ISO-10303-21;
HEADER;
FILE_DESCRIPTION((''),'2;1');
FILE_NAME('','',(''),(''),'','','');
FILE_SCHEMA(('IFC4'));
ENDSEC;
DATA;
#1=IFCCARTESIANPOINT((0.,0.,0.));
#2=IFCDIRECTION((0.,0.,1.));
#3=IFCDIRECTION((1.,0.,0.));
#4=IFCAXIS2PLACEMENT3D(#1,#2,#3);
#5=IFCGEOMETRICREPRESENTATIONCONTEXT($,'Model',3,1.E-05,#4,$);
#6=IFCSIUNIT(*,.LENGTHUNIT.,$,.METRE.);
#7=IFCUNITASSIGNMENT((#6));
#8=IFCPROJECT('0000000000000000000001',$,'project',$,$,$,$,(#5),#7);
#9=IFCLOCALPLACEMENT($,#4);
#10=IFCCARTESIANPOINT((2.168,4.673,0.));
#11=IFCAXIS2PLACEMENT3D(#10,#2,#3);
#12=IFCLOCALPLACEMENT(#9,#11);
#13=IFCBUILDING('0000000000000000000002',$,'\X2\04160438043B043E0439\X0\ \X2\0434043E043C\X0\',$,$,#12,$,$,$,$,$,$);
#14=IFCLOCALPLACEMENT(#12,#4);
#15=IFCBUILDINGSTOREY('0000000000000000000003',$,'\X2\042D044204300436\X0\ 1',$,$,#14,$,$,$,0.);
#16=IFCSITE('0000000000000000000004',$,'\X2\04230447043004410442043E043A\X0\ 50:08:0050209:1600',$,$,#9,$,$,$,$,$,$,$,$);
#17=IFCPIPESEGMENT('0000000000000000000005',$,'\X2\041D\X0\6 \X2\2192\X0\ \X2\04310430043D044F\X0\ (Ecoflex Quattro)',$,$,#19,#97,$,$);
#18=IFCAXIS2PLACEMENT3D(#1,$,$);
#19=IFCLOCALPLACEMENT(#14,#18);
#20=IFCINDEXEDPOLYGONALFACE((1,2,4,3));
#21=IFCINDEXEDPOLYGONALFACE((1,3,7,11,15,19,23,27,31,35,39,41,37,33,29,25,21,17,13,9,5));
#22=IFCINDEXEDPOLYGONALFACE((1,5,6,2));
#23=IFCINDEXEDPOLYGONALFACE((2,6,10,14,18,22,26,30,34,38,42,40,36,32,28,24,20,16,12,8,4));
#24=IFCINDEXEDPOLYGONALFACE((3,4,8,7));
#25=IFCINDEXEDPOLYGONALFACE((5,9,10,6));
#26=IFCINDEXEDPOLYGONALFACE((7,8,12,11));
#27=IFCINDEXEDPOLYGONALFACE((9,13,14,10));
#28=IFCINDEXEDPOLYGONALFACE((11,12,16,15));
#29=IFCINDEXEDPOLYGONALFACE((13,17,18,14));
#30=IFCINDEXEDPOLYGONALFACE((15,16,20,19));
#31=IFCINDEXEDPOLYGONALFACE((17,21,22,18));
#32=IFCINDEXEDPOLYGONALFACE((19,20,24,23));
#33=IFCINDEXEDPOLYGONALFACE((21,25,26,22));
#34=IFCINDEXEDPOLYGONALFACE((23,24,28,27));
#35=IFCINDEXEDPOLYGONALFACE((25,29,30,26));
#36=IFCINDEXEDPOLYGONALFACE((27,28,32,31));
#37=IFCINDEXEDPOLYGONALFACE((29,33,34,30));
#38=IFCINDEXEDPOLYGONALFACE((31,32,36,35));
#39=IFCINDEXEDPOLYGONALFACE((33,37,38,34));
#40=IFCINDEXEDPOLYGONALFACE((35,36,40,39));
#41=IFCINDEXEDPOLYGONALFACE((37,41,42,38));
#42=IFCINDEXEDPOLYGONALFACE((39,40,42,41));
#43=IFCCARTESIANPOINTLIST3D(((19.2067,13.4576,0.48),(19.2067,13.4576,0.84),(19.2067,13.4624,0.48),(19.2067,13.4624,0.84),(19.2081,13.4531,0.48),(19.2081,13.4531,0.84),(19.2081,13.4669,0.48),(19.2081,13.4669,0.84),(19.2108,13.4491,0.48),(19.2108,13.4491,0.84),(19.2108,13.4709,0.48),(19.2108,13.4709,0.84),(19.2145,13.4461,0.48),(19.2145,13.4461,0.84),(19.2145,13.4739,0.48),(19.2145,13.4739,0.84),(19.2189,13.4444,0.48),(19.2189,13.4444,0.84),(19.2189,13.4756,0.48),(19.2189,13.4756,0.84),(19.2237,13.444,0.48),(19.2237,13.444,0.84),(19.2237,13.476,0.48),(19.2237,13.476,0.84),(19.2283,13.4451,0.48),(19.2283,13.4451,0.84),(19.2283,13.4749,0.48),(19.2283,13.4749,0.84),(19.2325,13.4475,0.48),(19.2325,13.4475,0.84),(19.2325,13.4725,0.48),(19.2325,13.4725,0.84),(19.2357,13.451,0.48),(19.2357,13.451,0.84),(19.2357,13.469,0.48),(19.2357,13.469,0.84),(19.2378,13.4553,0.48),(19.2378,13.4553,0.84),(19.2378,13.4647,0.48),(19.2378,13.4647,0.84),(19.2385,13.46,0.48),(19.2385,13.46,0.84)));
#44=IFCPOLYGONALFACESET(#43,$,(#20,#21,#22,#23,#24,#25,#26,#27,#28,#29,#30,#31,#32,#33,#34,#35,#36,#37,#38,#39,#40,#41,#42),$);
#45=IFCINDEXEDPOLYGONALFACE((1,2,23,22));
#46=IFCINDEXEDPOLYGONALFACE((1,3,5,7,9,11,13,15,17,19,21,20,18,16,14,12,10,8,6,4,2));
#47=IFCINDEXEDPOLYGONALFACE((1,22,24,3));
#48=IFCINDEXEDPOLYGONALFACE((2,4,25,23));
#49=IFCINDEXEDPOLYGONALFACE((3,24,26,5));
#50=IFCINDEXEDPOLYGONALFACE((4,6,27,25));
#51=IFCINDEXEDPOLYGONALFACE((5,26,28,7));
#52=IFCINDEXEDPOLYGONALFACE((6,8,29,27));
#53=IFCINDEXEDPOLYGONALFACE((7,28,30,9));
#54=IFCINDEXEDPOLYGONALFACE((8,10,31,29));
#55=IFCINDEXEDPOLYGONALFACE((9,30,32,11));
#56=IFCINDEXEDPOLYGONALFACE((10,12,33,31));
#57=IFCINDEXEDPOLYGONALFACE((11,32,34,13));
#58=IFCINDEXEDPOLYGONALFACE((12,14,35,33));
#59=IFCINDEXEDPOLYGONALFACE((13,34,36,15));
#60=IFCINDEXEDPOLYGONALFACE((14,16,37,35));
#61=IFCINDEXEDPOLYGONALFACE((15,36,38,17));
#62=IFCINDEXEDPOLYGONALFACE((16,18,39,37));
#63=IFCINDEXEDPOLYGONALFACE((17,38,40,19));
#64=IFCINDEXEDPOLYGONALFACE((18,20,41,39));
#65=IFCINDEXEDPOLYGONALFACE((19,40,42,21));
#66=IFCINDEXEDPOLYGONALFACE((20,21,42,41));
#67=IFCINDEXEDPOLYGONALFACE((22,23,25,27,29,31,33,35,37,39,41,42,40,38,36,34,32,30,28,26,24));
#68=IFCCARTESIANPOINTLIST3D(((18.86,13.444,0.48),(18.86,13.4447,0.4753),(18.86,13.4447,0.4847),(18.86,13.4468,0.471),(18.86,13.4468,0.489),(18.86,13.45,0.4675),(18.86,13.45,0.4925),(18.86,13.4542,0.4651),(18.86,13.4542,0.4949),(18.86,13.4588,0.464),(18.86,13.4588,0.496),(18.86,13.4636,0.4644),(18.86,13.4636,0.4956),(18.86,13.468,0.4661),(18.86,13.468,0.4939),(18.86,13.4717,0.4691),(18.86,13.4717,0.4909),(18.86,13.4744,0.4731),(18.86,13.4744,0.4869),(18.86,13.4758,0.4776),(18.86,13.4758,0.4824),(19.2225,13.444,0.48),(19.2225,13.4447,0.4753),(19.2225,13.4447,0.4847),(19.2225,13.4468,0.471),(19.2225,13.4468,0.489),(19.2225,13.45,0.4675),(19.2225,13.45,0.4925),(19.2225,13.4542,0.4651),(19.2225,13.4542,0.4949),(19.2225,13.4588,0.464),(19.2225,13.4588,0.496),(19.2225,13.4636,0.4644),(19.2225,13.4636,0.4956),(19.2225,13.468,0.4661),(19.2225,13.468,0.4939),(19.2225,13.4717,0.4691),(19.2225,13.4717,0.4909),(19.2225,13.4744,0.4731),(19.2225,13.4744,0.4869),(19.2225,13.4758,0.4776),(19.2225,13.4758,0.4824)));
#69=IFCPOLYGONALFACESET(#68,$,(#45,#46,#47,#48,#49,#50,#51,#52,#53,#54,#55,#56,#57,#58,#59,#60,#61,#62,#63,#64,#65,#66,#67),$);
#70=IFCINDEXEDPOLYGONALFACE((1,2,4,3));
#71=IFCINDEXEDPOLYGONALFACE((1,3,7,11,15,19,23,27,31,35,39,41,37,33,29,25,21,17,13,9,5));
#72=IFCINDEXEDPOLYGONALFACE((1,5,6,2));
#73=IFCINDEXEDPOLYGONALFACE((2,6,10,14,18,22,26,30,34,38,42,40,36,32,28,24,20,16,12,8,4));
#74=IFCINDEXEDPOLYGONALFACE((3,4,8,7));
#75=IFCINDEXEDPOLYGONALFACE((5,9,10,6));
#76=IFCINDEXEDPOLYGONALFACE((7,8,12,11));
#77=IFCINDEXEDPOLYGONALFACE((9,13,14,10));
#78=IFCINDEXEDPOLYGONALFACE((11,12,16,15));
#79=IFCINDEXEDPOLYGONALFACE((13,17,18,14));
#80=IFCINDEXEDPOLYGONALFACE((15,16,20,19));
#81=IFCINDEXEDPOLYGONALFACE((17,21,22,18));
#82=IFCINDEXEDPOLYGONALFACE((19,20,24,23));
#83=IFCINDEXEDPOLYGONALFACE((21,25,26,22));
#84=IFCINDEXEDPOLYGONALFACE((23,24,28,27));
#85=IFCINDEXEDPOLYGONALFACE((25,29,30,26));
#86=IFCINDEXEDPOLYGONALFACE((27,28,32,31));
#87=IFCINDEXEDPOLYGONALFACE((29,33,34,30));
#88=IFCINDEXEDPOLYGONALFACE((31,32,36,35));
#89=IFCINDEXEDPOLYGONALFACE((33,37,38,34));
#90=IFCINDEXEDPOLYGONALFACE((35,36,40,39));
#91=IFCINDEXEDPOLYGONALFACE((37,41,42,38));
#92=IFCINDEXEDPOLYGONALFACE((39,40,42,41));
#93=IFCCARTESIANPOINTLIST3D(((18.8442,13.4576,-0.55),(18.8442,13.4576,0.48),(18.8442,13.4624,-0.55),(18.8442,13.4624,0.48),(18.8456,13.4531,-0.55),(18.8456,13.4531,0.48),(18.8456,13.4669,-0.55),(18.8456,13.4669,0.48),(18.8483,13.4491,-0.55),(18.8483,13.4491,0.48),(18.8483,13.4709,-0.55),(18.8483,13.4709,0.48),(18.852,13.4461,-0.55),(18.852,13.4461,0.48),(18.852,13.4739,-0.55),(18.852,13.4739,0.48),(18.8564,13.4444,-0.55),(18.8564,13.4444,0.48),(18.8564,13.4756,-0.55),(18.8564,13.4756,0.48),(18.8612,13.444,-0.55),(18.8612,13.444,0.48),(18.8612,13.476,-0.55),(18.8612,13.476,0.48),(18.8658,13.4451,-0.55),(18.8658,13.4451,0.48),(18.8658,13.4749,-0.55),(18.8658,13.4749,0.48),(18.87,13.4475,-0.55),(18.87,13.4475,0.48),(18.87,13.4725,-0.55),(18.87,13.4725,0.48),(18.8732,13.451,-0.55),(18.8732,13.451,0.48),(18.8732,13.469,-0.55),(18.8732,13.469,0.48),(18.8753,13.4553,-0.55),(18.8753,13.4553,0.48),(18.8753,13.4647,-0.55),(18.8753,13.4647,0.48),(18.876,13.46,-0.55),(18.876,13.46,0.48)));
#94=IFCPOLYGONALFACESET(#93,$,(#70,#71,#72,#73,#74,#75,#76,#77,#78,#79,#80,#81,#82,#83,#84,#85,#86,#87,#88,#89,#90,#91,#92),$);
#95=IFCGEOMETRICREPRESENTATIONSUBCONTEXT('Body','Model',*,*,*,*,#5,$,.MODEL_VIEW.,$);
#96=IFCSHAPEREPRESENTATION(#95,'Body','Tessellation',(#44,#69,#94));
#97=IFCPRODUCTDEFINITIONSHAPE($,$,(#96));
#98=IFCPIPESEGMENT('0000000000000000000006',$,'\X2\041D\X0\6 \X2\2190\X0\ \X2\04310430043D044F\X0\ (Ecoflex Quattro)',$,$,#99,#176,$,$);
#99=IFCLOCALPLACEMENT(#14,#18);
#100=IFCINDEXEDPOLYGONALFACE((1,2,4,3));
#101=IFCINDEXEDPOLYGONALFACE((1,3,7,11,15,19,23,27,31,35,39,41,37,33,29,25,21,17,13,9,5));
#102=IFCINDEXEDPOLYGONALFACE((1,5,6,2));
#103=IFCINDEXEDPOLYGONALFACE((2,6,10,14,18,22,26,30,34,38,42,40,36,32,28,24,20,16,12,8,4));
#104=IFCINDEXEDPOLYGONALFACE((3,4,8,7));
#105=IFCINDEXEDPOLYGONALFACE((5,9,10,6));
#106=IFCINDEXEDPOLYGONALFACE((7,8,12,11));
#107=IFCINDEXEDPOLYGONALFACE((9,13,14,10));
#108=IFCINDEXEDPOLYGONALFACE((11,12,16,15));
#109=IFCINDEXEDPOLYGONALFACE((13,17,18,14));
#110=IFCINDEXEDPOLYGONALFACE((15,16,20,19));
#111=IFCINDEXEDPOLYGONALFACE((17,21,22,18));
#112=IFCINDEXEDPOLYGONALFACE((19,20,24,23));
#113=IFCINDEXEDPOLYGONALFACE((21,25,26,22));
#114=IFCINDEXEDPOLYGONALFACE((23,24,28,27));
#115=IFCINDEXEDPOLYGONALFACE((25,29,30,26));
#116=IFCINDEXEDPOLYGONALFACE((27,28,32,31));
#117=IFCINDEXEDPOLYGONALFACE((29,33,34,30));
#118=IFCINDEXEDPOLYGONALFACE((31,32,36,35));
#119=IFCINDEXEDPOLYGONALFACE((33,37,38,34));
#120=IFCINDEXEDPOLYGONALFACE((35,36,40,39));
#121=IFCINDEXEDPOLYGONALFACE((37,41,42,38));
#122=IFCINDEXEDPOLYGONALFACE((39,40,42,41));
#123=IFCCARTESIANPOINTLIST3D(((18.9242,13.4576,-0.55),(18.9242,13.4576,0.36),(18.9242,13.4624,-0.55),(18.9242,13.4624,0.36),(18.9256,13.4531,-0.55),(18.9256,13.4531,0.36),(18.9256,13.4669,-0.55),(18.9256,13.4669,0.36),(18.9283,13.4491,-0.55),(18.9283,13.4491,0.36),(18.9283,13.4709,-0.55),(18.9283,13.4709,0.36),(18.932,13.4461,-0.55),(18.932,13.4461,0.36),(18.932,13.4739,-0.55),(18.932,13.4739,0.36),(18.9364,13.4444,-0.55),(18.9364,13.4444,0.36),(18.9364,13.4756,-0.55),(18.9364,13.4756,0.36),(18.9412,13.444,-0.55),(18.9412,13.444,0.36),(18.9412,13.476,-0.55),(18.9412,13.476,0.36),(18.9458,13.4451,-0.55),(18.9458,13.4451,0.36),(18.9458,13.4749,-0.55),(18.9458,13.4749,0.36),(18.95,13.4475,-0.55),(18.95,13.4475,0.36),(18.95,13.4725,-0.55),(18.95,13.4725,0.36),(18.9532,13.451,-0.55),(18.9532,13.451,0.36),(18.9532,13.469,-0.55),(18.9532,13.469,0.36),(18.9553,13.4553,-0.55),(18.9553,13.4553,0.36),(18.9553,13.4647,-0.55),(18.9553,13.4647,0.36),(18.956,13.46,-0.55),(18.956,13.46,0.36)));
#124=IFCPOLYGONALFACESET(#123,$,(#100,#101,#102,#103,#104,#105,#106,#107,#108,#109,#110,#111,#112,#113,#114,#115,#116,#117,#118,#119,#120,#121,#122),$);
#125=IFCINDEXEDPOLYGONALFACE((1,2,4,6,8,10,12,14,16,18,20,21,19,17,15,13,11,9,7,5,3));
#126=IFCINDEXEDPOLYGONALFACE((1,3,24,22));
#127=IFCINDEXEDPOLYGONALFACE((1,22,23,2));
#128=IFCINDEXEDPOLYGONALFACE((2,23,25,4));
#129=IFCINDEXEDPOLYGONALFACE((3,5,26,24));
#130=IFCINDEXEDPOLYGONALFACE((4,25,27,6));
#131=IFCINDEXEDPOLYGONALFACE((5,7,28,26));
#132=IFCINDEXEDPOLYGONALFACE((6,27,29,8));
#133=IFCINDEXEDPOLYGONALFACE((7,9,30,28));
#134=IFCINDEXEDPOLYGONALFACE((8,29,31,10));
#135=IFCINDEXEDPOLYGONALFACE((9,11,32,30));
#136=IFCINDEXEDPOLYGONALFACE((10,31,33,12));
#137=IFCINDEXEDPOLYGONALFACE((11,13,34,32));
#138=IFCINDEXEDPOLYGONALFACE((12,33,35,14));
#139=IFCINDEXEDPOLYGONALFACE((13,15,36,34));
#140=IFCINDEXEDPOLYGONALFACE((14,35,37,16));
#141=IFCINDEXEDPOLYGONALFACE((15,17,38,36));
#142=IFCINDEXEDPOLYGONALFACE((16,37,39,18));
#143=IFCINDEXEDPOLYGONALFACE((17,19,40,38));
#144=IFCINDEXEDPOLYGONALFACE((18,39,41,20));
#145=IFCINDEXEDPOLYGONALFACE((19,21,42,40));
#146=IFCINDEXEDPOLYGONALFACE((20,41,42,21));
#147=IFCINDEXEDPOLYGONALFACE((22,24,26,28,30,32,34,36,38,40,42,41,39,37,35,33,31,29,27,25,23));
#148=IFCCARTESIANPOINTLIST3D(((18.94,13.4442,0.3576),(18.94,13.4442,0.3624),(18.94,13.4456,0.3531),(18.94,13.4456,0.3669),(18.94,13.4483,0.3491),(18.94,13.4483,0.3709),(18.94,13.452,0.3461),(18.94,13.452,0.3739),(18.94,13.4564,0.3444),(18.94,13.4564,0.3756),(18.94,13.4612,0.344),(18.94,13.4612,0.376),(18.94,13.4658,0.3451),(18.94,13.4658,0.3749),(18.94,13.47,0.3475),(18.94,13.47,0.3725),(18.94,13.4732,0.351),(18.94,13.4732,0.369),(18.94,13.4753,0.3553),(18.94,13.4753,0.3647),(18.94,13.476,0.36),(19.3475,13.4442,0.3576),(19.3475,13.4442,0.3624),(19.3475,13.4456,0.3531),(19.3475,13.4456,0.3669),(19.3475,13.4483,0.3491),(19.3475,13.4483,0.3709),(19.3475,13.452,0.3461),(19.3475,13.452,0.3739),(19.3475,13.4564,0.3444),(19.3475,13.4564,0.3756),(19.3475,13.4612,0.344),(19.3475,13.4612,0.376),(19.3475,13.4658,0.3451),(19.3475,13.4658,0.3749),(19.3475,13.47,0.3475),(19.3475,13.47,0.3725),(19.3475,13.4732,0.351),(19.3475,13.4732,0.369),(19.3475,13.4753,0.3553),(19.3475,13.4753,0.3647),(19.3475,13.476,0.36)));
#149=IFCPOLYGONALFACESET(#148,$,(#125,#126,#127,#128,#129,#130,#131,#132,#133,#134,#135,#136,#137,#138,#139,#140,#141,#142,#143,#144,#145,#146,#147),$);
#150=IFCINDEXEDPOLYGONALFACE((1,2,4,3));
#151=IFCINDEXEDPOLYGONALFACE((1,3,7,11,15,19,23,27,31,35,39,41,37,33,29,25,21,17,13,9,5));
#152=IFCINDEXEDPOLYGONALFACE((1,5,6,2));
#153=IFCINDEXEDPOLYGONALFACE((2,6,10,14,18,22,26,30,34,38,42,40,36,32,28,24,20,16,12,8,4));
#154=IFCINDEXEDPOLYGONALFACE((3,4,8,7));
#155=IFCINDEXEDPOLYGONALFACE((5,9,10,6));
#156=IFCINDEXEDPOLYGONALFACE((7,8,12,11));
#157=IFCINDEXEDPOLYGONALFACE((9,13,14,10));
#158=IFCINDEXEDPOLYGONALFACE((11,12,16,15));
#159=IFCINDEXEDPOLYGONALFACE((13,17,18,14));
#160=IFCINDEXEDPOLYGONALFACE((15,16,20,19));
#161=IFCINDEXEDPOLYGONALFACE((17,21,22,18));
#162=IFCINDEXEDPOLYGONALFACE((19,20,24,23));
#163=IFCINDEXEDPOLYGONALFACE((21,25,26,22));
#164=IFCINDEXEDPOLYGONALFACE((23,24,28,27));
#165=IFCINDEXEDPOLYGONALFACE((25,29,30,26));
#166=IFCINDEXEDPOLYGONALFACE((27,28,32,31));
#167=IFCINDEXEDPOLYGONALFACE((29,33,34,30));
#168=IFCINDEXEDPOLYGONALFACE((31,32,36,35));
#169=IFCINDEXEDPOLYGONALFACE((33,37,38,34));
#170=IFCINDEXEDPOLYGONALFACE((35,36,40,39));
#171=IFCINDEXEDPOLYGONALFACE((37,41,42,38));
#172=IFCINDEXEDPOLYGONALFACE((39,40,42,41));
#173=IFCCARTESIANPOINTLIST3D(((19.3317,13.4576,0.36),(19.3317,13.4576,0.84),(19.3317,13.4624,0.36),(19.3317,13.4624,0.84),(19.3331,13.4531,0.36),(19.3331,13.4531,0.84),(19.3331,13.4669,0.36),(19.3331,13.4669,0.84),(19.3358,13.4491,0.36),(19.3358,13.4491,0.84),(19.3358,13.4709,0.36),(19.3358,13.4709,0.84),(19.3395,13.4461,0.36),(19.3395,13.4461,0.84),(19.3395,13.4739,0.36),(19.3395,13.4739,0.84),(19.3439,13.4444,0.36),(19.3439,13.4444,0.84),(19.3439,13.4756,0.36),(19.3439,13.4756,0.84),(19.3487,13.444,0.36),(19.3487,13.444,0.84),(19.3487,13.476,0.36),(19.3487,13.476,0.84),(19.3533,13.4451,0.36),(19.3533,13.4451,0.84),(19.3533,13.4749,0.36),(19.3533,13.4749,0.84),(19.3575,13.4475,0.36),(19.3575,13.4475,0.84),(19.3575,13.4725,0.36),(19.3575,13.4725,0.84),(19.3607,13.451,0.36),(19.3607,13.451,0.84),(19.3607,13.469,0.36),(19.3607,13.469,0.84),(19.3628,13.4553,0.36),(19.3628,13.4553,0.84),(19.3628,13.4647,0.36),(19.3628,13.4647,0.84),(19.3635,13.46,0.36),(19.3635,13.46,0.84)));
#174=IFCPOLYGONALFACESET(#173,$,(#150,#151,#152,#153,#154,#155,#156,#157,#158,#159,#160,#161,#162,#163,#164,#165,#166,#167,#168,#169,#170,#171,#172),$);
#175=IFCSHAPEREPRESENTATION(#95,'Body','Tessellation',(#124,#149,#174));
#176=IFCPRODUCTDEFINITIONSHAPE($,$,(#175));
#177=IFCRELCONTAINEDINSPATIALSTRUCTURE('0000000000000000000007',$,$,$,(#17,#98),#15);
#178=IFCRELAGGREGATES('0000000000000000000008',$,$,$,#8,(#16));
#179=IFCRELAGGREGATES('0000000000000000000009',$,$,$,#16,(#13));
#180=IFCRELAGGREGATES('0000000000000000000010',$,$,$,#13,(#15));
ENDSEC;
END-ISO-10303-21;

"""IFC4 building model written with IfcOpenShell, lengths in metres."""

from ifc_helpers import new_model, si_unit, frame, origin_with_axes, origin_2d, place, context, subcontext, project, spatial, circle, extrude, element, save


model = new_model("IFC4")

# Units and contexts
model_context = context("Model", 3, precision=1e-05, world=origin_with_axes())
body_context = subcontext(model_context, "Body", "Model", "MODEL_VIEW")
ifc_project = project(units=[si_unit("LENGTHUNIT", "METRE")], contexts=[model_context])

# Site, building, storey
site_placement = place(None, origin_with_axes())
site = spatial("IfcSite", under=ifc_project, at=site_placement, Name="Участок 50:08:0050209:1600")
building_placement = place(site_placement, frame((2.168, 4.673, 0.0), z_axis=(0.0, 0.0, 1.0), x_axis=(1.0, 0.0, 0.0)))
building = spatial("IfcBuilding", under=site, at=building_placement, Name="Жилой дом")
storey_placement = place(building_placement, origin_with_axes())
storey = spatial("IfcBuildingStorey", under=building, at=storey_placement, Name="Этаж 1", Elevation=0.0)

# Pipe segments
pipe_segment_1_placement = place(storey_placement, origin_with_axes())
element("IfcPipeSegment", 1, at=pipe_segment_1_placement, inside=storey, Name="Н6 → баня (Ecoflex Quattro)", context=body_context, shape_type="SweptSolid", body=[
    extrude(circle(Radius=0.016, at=origin_2d()), frame((19.2225, 13.46, 0.84), z_axis=(0.0, 0.0, -1.0), x_axis=(1.0, 0.0, 0.0)), (0.0, 0.0, 1.0), 0.36),
    extrude(circle(Radius=0.016, at=origin_2d()), frame((19.2225, 13.46, 0.48), z_axis=(-1.0, 0.0, 0.0), x_axis=(0.0, -1.0, 0.0)), (0.0, 0.0, 1.0), 0.3625),
    extrude(circle(Radius=0.016, at=origin_2d()), frame((18.86, 13.46, 0.48), z_axis=(0.0, 0.0, -1.0), x_axis=(1.0, 0.0, 0.0)), (0.0, 0.0, 1.0), 1.03),
])
pipe_segment_2_placement = place(storey_placement, origin_with_axes())
element("IfcPipeSegment", 2, at=pipe_segment_2_placement, inside=storey, Name="Н6 ← баня (Ecoflex Quattro)", context=body_context, shape_type="SweptSolid", body=[
    extrude(circle(Radius=0.016, at=origin_2d()), frame((18.94, 13.46, -0.55), z_axis=(0.0, 0.0, 1.0), x_axis=(1.0, 0.0, 0.0)), (0.0, 0.0, 1.0), 0.91),
    extrude(circle(Radius=0.016, at=origin_2d()), frame((18.94, 13.46, 0.36), z_axis=(1.0, 0.0, 0.0), x_axis=(0.0, 1.0, 0.0)), (0.0, 0.0, 1.0), 0.4075),
    extrude(circle(Radius=0.016, at=origin_2d()), frame((19.3475, 13.46, 0.36), z_axis=(0.0, 0.0, 1.0), x_axis=(1.0, 0.0, 0.0)), (0.0, 0.0, 1.0), 0.48),
])

save(model, "model.ifc")
